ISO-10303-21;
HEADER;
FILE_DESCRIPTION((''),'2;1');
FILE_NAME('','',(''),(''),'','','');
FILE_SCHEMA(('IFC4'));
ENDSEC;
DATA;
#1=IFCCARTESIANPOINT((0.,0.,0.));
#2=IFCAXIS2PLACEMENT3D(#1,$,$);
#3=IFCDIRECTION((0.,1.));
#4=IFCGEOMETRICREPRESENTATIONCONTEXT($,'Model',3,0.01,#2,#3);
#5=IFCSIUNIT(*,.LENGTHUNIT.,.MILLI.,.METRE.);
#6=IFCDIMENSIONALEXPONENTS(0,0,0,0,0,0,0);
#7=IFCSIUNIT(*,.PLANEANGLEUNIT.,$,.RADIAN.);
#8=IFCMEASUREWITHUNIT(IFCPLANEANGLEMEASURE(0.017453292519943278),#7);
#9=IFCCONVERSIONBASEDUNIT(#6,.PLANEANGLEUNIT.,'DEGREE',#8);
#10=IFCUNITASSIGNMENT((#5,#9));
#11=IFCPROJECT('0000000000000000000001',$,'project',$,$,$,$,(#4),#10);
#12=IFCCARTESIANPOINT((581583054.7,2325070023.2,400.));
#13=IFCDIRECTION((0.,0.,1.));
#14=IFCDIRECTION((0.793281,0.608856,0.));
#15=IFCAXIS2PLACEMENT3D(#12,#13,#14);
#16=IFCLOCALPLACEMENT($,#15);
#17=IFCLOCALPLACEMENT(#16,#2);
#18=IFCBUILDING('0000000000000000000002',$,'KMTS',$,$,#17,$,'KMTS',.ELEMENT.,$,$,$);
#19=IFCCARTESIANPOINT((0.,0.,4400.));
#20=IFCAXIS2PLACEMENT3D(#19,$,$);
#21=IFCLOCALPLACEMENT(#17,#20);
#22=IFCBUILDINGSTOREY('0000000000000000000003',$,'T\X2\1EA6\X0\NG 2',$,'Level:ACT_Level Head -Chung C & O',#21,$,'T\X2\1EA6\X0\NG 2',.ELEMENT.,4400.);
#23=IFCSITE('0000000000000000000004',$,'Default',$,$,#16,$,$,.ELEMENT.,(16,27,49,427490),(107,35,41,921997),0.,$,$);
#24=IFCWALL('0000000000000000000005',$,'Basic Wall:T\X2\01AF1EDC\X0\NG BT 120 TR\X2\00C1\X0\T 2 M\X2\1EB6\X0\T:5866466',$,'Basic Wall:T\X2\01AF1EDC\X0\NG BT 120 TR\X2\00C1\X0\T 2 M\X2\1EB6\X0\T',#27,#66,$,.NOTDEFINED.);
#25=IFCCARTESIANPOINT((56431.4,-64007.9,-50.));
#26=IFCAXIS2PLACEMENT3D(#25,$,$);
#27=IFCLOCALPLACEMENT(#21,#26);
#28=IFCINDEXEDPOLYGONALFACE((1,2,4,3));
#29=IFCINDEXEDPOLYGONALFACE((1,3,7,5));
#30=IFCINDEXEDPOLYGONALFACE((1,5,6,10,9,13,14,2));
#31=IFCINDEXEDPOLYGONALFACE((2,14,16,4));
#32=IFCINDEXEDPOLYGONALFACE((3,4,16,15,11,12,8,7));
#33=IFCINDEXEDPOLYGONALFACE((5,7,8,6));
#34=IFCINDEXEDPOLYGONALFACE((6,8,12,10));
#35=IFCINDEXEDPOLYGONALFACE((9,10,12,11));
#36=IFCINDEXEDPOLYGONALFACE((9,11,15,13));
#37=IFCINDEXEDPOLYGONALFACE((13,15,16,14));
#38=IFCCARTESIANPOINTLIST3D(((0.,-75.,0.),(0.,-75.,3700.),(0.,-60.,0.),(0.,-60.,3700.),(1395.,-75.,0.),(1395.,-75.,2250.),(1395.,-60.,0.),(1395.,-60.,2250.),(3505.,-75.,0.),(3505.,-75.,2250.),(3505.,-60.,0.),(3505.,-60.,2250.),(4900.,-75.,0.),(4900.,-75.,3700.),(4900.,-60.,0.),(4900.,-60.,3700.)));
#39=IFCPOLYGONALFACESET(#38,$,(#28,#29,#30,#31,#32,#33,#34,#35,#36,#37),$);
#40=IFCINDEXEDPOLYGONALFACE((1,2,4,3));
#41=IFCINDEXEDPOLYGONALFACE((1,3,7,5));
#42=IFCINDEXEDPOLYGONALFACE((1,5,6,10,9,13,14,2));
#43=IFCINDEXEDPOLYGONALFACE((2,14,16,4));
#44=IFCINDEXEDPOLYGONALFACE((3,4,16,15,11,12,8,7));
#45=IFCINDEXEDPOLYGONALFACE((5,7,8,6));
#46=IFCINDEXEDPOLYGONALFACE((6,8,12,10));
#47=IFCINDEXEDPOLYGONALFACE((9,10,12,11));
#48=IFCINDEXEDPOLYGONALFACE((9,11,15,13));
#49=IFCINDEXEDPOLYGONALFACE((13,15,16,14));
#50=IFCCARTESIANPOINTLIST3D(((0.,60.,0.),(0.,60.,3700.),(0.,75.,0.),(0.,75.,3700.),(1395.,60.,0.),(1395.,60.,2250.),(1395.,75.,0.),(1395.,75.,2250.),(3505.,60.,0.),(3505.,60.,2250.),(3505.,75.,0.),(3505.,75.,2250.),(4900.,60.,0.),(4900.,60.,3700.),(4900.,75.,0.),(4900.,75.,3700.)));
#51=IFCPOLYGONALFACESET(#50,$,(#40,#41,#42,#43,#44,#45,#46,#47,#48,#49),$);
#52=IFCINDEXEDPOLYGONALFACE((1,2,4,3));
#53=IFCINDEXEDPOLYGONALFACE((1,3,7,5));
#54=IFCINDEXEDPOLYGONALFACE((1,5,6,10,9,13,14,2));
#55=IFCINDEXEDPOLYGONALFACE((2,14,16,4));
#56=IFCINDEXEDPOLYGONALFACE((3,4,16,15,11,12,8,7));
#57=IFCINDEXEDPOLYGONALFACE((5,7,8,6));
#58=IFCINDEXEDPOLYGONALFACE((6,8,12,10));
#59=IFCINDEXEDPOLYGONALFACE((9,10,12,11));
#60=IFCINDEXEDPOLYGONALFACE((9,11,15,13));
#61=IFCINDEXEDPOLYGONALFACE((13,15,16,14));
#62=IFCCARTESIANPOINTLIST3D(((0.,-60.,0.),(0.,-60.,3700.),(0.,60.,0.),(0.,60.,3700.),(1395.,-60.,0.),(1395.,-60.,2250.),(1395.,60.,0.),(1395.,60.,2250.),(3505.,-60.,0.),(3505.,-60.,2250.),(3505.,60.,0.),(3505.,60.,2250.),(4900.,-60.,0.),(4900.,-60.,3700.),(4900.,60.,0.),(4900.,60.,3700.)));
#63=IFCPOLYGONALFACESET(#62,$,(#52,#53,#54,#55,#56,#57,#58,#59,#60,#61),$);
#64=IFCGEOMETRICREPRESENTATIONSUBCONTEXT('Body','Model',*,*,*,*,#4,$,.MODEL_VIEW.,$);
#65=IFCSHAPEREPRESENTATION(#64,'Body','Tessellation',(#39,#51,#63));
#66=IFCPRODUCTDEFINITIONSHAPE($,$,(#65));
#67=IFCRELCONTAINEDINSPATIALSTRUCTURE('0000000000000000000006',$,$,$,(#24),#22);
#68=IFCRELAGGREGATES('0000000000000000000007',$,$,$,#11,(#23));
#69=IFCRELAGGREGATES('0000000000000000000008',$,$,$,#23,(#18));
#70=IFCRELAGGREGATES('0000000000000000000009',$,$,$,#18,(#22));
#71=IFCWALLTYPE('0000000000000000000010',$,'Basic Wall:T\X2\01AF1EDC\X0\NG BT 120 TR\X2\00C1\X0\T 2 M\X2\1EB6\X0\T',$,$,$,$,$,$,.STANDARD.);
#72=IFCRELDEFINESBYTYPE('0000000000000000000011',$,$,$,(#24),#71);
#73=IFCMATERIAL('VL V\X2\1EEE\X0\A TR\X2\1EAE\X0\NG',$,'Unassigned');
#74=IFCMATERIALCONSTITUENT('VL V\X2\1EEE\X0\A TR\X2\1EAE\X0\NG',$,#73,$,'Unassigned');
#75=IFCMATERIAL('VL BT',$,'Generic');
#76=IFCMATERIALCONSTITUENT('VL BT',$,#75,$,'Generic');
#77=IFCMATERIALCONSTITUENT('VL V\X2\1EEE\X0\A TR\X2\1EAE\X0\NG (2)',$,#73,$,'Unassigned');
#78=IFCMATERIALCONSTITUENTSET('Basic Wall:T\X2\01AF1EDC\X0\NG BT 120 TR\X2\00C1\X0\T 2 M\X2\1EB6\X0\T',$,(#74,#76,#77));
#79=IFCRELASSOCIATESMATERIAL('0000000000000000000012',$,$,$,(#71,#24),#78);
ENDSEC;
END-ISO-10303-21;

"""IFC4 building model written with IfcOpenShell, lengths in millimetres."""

from ifc_helpers import new_model, entity, si_unit, converted_unit, direction, frame, origin, place, context, subcontext, project, spatial, indexed_curve, outline, extrude, material, constituent, constituent_set, type_object, element, save


model = new_model("IFC4")

# Units and contexts
model_context = context("Model", 3, precision=0.01, world=origin(), true_north=direction((0.0, 1.0)))
body_context = subcontext(model_context, "Body", "Model", "MODEL_VIEW")
ifc_project = project(units=[si_unit("LENGTHUNIT", "METRE", prefix="MILLI"), converted_unit("PLANEANGLEUNIT", "DEGREE", entity("IfcPlaneAngleMeasure", 0.017453292519943278), si_unit("PLANEANGLEUNIT", "RADIAN"), dimensions=[0, 0, 0, 0, 0, 0, 0])], contexts=[model_context])

# Site, building, storey
site_placement = place(None, frame((581583054.7, 2325070023.2, 400.0), z_axis=(0.0, 0.0, 1.0), x_axis=(0.793281, 0.608856, 0.0)))
site = spatial("IfcSite", under=ifc_project, at=site_placement, Name="Default", CompositionType="ELEMENT", RefLatitude=(16, 27, 49, 427490), RefLongitude=(107, 35, 41, 921997), RefElevation=0.0)
building_placement = place(site_placement, origin())
building = spatial("IfcBuilding", under=site, at=building_placement, Name="KMTS", LongName="KMTS", CompositionType="ELEMENT")
storey_placement = place(building_placement, frame((0.0, 0.0, 4400.0)))
storey = spatial("IfcBuildingStorey", under=building, at=storey_placement, Name="TẦNG 2", ObjectType="Level:ACT_Level Head -Chung C & O", LongName="TẦNG 2", CompositionType="ELEMENT", Elevation=4400.0)

# Shared definitions
ifc_material_1 = material(Name="VL VỮA TRẮNG", Category="Unassigned")
ifc_material_2 = material(Name="VL BT", Category="Generic")

# Wall, opening
ifc_constituent_1 = constituent(ifc_material_1, Name="VL VỮA TRẮNG", Category="Unassigned")
ifc_constituent_2 = constituent(ifc_material_2, Name="VL BT", Category="Generic")
ifc_constituent_3 = constituent(ifc_material_1, Name="VL VỮA TRẮNG (2)", Category="Unassigned")
ifc_constituent_set_1 = constituent_set(constituents=[ifc_constituent_1, ifc_constituent_2, ifc_constituent_3], Name="Basic Wall:TƯỜNG BT 120 TRÁT 2 MẶT")
wall_type_1 = type_object("IfcWallType", Name="Basic Wall:TƯỜNG BT 120 TRÁT 2 MẶT", PredefinedType="STANDARD", material=ifc_constituent_set_1)
wall_1_placement = place(storey_placement, frame((56431.4, -64007.9, -50.0)))
wall_1 = element("IfcWall", 1, at=wall_1_placement, inside=storey, type_object=wall_type_1, material=ifc_constituent_set_1, Name="Basic Wall:TƯỜNG BT 120 TRÁT 2 MẶT:5866466", ObjectType="Basic Wall:TƯỜNG BT 120 TRÁT 2 MẶT", PredefinedType="NOTDEFINED", context=body_context, shape_type="SweptSolid", body=[
    extrude(outline(indexed_curve([(-2450.0, -1487.5), (-1055.0, -1487.5), (-1055.0, 762.5), (1055.0, 762.5), (1055.0, -1487.5), (2450.0, -1487.5), (2450.0, 2212.5), (-2450.0, 2212.5), (-2450.0, -1487.5)], self_intersect=False)), frame((2450.0, -75.0, 1487.5), z_axis=(0.0, 1.0, 0.0), x_axis=(-1.0, 0.0, 0.0)), (0.0, 0.0, 1.0), 15.0),
    extrude(outline(indexed_curve([(-1487.5, -1055.0), (-1487.5, -2450.0), (2212.5, -2450.0), (2212.5, 2450.0), (-1487.5, 2450.0), (-1487.5, 1055.0), (762.5, 1055.0), (762.5, -1055.0), (-1487.5, -1055.0)], self_intersect=False)), frame((2450.0, 60.0, 1487.5), z_axis=(0.0, -1.0, 0.0), x_axis=(0.0, 0.0, 1.0)), (0.0, 0.0, -1.0), 15.0),
    extrude(outline(indexed_curve([(-1487.5, -1055.0), (-1487.5, -2450.0), (2212.5, -2450.0), (2212.5, 2450.0), (-1487.5, 2450.0), (-1487.5, 1055.0), (762.5, 1055.0), (762.5, -1055.0), (-1487.5, -1055.0)], self_intersect=False)), frame((2450.0, -60.0, 1487.5), z_axis=(0.0, -1.0, 0.0), x_axis=(0.0, 0.0, 1.0)), (0.0, 0.0, -1.0), 120.0),
])
opening_1_placement = place(wall_1_placement, frame((3505.0, 75.0, 0.0)))
element("IfcOpeningElement", 2, at=opening_1_placement, cuts=wall_1, PredefinedType="OPENING", context=body_context, shape_type="SweptSolid", body=[
    extrude(outline(indexed_curve([(2250.0, 2110.0), (0.0, 2110.0), (0.0, 0.0), (2250.0, 0.0), (2250.0, 2110.0)], self_intersect=False)), frame((0.0, 0.0, 0.0), z_axis=(0.0, -1.0, 0.0), x_axis=(0.0, 0.0, 1.0)), (0.0, 0.0, 1.0), 150.0),
])

save(model, "model.ifc")
